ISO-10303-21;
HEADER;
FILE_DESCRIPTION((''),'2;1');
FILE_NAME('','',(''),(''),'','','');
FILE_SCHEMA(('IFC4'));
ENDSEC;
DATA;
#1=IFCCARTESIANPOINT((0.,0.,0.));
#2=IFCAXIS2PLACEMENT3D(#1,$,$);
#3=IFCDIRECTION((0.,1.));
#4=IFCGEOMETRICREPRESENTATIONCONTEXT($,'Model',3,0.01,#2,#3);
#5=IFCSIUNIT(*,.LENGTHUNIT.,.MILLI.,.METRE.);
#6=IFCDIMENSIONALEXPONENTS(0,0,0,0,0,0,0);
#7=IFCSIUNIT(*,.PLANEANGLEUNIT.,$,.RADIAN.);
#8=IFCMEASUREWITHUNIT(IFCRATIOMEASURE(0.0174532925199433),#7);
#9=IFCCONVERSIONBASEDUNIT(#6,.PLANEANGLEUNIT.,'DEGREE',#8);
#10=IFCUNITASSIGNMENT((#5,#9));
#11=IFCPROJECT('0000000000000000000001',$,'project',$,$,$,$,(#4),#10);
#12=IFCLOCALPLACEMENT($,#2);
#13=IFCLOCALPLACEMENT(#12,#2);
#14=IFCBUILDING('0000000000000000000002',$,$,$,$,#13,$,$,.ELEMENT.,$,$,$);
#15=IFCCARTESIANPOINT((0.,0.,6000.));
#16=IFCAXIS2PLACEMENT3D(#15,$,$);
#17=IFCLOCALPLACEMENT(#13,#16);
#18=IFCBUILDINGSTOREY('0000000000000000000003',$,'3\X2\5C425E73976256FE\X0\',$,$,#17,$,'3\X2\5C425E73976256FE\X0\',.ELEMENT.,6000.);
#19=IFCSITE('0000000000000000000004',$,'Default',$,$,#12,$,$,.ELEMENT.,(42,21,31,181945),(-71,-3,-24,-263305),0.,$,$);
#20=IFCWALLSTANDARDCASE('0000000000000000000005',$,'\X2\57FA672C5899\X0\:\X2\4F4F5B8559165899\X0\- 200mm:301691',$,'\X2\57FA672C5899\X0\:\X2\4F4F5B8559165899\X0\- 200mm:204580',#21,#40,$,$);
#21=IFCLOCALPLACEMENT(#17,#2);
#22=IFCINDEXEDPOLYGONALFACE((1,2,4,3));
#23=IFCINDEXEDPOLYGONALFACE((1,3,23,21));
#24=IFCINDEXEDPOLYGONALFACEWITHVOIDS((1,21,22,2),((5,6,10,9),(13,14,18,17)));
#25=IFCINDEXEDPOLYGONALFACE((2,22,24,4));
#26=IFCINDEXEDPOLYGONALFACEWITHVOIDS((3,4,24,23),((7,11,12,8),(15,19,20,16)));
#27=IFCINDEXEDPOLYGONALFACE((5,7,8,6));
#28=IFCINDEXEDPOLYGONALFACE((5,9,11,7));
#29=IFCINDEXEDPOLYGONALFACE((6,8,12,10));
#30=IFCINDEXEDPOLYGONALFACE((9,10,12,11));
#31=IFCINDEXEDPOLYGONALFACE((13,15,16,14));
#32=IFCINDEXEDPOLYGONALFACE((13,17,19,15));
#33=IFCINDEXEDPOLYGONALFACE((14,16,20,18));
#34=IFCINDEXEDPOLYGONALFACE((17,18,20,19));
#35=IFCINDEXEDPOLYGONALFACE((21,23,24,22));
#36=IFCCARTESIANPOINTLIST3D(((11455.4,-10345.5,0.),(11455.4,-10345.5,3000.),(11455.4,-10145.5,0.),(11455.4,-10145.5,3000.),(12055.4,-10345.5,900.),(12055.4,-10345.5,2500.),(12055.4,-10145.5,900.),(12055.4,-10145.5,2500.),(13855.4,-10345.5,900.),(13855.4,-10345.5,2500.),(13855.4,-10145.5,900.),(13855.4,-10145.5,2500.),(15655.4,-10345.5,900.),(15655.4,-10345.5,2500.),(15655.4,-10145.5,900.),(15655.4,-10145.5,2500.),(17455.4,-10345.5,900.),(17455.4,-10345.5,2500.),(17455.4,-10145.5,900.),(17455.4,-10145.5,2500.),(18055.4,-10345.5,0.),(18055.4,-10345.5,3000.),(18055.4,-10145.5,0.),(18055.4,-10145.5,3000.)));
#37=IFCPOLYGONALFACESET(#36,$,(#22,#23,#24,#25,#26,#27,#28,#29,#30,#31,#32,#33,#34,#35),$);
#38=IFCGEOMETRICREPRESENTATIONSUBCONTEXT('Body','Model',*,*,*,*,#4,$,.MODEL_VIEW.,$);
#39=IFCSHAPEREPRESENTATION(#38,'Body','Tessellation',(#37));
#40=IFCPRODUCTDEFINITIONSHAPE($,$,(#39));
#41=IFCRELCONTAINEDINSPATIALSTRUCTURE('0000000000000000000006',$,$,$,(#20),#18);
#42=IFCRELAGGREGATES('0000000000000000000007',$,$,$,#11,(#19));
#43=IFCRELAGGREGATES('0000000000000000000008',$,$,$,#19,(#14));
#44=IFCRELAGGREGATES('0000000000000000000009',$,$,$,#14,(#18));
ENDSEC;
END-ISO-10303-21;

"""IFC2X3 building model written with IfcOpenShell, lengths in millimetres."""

from ifc_helpers import new_model, entity, si_unit, converted_unit, direction, frame, frame_2d, origin, place, context, subcontext, project, spatial, rectangle, extrude, element, save


model = new_model("IFC2X3")

# Units and contexts
model_context = context("Model", 3, precision=0.01, world=origin(), true_north=direction((0.0, 1.0)))
body_context = subcontext(model_context, "Body", "Model", "MODEL_VIEW")
ifc_project = project(units=[si_unit("LENGTHUNIT", "METRE", prefix="MILLI"), converted_unit("PLANEANGLEUNIT", "DEGREE", entity("IfcRatioMeasure", 0.0174532925199433), si_unit("PLANEANGLEUNIT", "RADIAN"), dimensions=[0, 0, 0, 0, 0, 0, 0])], contexts=[model_context])

# Site, building, storey
site_placement = place(None, origin())
site = spatial("IfcSite", under=ifc_project, at=site_placement, Name="Default", CompositionType="ELEMENT", RefLatitude=(42, 21, 31, 181945), RefLongitude=(-71, -3, -24, -263305), RefElevation=0.0)
building_placement = place(site_placement, origin())
building = spatial("IfcBuilding", under=site, at=building_placement, CompositionType="ELEMENT")
storey_placement = place(building_placement, frame((0.0, 0.0, 6000.0)))
storey = spatial("IfcBuildingStorey", under=building, at=storey_placement, Name="3层平面图", LongName="3层平面图", CompositionType="ELEMENT", Elevation=6000.0)

# Wall, openings
wall_placement = place(storey_placement, frame((11455.4, -10245.5, 0.0)))
wall = element("IfcWallStandardCase", 1, at=wall_placement, inside=storey, Name="基本墙:住宅外墙- 200mm:301691", ObjectType="基本墙:住宅外墙- 200mm:204580", context=body_context, shape_type="SweptSolid", body=[
    extrude(rectangle(XDim=6600.0, YDim=200.0, at=frame_2d((3300.0, 0.0), x_axis=(-1.0, 0.0))), origin(), (0.0, 0.0, 1.0), 3000.0),
])
opening_1_placement = place(wall_placement, frame((600.0, -100.0, 900.0)))
element("IfcOpeningElement", 2, at=opening_1_placement, cuts=wall, ObjectType="Opening", context=body_context, shape_type="SweptSolid", body=[
    extrude(rectangle(XDim=1600.0, YDim=1800.0, at=frame_2d((800.0, 900.0), x_axis=(1.0, 0.0))), frame((0.0, 0.0, 0.0), z_axis=(0.0, 1.0, 0.0), x_axis=(0.0, 0.0, 1.0)), (0.0, 0.0, 1.0), 200.0),
])
opening_2_placement = place(wall_placement, frame((4200.0, -100.0, 900.0)))
element("IfcOpeningElement", 3, at=opening_2_placement, cuts=wall, ObjectType="Opening", context=body_context, shape_type="SweptSolid", body=[
    extrude(rectangle(XDim=1600.0, YDim=1800.0, at=frame_2d((800.0, 900.0), x_axis=(1.0, 0.0))), frame((0.0, 0.0, 0.0), z_axis=(0.0, 1.0, 0.0), x_axis=(0.0, 0.0, 1.0)), (0.0, 0.0, 1.0), 200.0),
])

save(model, "model.ifc")
